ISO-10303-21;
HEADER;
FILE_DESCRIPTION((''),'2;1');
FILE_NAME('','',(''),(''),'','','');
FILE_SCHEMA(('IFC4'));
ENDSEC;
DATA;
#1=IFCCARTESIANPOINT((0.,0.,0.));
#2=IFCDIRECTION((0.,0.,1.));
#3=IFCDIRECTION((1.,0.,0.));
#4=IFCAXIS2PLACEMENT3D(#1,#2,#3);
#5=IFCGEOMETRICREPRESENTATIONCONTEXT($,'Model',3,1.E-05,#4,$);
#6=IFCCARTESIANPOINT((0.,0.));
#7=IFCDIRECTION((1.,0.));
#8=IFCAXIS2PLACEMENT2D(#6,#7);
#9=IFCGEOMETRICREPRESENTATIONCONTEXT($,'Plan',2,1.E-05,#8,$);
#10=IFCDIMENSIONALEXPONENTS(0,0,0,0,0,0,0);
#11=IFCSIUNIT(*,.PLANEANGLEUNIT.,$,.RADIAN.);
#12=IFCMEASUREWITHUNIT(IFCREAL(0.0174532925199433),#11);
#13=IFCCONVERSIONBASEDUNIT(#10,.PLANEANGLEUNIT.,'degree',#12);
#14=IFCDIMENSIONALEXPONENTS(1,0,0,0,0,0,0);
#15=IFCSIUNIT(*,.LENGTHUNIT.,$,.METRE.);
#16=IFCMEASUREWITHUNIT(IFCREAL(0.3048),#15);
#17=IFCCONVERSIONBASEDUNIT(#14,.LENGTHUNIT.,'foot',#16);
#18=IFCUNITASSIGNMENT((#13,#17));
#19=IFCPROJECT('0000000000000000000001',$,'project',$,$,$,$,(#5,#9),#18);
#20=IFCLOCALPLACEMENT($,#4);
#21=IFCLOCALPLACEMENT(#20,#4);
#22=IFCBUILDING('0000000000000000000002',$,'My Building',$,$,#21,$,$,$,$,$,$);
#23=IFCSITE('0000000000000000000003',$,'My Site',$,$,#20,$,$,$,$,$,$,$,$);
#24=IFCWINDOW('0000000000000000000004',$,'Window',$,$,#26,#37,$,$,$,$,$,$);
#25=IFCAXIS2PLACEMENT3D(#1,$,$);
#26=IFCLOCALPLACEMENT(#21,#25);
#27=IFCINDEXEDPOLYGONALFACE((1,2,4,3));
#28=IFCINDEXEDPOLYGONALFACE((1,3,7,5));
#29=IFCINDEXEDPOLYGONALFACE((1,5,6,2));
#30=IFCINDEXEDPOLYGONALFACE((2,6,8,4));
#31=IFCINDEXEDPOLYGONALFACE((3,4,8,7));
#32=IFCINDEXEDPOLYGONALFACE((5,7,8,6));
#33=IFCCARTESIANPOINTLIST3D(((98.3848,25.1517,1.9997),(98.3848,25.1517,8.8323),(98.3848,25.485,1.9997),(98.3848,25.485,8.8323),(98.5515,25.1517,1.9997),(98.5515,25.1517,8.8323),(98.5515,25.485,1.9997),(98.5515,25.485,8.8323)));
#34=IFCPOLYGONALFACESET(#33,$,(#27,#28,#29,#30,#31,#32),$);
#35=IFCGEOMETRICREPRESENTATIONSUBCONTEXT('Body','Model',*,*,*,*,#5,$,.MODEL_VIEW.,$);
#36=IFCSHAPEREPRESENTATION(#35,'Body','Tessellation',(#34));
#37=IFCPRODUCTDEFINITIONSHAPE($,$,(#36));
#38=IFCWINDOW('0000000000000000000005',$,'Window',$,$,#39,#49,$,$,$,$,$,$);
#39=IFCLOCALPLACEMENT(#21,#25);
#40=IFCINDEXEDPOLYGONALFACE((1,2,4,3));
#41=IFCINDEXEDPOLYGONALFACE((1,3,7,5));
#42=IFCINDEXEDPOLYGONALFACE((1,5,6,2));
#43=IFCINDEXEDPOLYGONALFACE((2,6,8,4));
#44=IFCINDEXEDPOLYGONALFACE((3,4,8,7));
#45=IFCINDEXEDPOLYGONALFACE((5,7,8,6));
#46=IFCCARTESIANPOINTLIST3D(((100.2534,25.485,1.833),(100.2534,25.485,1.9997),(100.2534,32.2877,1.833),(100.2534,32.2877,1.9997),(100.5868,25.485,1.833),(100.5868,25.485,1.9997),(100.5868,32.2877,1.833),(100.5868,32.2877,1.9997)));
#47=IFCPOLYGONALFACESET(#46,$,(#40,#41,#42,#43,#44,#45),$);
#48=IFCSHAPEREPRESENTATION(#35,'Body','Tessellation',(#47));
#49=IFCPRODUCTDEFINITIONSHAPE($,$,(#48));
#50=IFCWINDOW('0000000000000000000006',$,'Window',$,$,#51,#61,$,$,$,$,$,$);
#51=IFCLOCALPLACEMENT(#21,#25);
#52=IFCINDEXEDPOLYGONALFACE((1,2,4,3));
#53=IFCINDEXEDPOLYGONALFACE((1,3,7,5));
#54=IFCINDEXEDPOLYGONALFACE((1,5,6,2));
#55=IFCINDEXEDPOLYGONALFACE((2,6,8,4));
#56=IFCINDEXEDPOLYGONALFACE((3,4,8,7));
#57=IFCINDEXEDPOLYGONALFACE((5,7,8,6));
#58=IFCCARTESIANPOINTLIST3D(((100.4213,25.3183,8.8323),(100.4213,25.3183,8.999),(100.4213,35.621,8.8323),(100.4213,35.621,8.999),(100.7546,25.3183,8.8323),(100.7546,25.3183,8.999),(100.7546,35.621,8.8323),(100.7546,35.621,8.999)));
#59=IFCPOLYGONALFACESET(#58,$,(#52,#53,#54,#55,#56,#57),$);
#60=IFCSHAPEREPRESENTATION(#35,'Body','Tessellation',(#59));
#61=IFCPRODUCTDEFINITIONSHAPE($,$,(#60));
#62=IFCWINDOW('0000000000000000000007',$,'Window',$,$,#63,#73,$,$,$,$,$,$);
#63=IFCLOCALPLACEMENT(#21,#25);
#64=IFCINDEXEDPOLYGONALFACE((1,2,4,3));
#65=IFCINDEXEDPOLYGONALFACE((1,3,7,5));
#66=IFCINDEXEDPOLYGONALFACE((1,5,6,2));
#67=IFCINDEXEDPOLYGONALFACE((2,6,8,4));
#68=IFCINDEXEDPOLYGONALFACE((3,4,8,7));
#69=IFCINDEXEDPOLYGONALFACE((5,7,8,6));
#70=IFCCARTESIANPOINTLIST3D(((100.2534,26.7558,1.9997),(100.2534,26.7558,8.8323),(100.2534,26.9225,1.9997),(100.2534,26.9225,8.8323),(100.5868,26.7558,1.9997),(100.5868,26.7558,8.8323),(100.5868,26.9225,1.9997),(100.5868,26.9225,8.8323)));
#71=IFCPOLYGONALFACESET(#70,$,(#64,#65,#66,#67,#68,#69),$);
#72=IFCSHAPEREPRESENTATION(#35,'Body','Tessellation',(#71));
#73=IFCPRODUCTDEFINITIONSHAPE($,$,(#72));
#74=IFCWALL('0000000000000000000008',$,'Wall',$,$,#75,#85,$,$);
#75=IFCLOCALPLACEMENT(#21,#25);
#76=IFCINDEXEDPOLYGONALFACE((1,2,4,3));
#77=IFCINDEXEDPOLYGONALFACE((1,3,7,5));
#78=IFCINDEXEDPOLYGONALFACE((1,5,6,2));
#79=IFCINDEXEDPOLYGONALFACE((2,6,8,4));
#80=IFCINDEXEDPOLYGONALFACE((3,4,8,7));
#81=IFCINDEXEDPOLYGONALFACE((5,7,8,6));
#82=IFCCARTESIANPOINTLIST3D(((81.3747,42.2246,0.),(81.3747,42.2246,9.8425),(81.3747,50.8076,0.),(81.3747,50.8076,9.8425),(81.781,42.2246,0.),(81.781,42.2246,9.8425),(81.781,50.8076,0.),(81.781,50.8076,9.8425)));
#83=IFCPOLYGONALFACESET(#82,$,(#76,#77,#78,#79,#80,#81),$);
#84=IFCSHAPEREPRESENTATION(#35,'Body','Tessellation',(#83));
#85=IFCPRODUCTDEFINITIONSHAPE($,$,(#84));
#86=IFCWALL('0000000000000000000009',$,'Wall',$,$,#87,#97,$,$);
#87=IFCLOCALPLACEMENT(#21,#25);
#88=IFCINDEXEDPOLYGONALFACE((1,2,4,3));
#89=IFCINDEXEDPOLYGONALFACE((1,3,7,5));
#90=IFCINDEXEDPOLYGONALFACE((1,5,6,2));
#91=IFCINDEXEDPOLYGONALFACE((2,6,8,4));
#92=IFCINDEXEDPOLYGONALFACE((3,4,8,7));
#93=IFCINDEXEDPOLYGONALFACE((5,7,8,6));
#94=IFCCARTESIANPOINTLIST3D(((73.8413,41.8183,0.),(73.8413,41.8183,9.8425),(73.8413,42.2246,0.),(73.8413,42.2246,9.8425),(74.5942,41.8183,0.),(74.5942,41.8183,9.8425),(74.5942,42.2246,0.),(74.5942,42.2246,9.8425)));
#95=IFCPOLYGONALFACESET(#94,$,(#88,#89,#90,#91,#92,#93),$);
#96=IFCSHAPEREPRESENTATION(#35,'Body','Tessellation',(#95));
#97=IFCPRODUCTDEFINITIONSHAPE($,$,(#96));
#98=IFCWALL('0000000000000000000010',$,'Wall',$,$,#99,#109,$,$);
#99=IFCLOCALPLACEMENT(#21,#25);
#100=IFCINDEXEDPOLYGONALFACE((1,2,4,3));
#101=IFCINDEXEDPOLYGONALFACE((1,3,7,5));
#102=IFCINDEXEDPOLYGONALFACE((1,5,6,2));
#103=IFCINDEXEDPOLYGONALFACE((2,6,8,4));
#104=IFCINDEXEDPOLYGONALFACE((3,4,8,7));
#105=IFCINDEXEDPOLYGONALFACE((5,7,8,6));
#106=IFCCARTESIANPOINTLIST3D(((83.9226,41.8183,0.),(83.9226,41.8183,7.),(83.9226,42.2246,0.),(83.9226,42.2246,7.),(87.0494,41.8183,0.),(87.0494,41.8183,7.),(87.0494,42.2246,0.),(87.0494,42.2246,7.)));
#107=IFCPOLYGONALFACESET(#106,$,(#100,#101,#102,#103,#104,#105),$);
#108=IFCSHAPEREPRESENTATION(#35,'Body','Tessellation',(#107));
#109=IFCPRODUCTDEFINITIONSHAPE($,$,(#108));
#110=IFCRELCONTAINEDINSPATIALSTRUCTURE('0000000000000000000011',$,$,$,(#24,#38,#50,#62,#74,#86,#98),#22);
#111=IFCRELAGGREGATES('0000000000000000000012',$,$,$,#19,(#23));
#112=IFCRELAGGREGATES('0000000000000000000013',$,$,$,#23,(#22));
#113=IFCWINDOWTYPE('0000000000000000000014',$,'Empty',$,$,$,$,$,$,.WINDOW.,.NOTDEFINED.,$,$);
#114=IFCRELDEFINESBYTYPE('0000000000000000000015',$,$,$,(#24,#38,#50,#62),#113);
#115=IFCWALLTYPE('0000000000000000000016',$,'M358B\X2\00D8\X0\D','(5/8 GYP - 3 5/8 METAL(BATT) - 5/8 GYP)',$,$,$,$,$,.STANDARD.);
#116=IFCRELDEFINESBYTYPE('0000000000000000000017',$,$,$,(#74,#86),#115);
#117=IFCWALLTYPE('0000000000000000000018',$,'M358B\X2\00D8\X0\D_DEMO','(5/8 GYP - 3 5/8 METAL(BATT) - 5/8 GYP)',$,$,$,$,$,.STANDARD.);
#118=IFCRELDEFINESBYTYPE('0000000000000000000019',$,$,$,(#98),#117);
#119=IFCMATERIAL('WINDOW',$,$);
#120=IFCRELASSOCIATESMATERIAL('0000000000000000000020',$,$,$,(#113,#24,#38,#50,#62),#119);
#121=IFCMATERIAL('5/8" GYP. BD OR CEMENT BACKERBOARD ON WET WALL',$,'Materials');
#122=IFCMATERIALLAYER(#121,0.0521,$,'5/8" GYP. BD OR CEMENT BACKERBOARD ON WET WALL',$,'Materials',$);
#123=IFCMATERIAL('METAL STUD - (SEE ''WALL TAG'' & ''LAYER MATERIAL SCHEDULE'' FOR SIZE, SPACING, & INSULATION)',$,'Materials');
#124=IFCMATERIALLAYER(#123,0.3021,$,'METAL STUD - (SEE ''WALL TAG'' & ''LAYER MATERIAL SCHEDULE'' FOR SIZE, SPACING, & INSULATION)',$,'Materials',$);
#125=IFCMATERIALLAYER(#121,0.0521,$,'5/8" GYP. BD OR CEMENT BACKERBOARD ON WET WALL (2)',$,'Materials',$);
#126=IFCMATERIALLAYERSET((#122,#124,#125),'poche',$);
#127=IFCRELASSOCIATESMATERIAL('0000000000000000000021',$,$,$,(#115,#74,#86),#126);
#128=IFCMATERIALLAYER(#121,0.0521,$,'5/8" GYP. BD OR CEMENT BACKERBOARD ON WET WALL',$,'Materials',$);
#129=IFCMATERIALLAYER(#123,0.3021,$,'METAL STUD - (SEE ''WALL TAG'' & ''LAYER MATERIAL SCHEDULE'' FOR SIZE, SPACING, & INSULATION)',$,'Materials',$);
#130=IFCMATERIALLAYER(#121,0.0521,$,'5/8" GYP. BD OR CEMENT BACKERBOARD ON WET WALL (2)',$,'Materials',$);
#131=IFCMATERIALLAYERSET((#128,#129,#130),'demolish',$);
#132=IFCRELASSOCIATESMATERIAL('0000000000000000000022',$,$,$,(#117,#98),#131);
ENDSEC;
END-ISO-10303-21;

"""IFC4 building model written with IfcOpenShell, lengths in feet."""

from ifc_helpers import new_model, entity, si_unit, converted_unit, frame, origin_with_axes, origin_2d_with_axis, place, context, subcontext, project, spatial, indexed_curve, rectangle, outline, extrude, material, layer, layer_set, layer_usage, material_profile, profile_set, profile_usage, type_object, element, save


model = new_model("IFC4")

# Units and contexts
model_context = context("Model", 3, precision=1e-05, world=origin_with_axes())
plan_context = context("Plan", 2, precision=1e-05, world=origin_2d_with_axis())
body_context_1 = subcontext(model_context, "Body", "Model", "MODEL_VIEW")
ifc_project = project(units=[converted_unit("PLANEANGLEUNIT", "degree", entity("IfcReal", 0.0174532925199433), si_unit("PLANEANGLEUNIT", "RADIAN"), dimensions=[0, 0, 0, 0, 0, 0, 0]), converted_unit("LENGTHUNIT", "foot", entity("IfcReal", 0.3048), si_unit("LENGTHUNIT", "METRE"), dimensions=[1, 0, 0, 0, 0, 0, 0])], contexts=[model_context, plan_context])

# Site, building
site_placement = place(None, origin_with_axes())
site = spatial("IfcSite", under=ifc_project, at=site_placement, Name="My Site")
building_placement = place(site_placement, origin_with_axes())
building = spatial("IfcBuilding", under=site, at=building_placement, Name="My Building")

# Shared definitions
ifc_material_1 = material(Name="WINDOW")

# Shared definitions
ifc_material_2 = material(Name="5/8\" GYP. BD OR CEMENT BACKERBOARD ON WET WALL", Category="Materials")
ifc_material_3 = material(Name="METAL STUD - (SEE 'WALL TAG' & 'LAYER MATERIAL SCHEDULE' FOR SIZE, SPACING, & INSULATION)", Category="Materials")

# Windows
ifc_material_profile = material_profile(ifc_material_1, rectangle(XDim=0.3333, YDim=0.1667, at=origin_2d_with_axis()))
ifc_profile_set = profile_set([ifc_material_profile], Name="existing")
window_type = type_object("IfcWindowType", Name="Empty", PartitioningType="NOTDEFINED", PredefinedType="WINDOW", material=ifc_profile_set)
ifc_profile_usage_1 = profile_usage(ifc_profile_set, cardinal=5)
window_1_placement = place(building_placement, frame((98.4681, 25.3183, 1.9997), z_axis=(0.000001, 0.0, 1.0), x_axis=(0.0, 1.0, 0.0)))
element("IfcWindow", 1, at=window_1_placement, inside=building, type_object=window_type, material=ifc_profile_usage_1, Name="Window", context=body_context_1, shape_type="SweptSolid", body=[
    extrude(rectangle(XDim=0.3333, YDim=0.1667, at=origin_2d_with_axis()), origin_with_axes(), (0.0, 0.0, 1.0), 6.8327),
])
ifc_profile_usage_2 = profile_usage(ifc_profile_set, cardinal=5)
window_2_placement = place(building_placement, frame((100.4201, 32.2877, 1.9163), z_axis=(0.0, -1.0, 0.0), x_axis=(1.0, 0.0, 0.0)))
element("IfcWindow", 2, at=window_2_placement, inside=building, type_object=window_type, material=ifc_profile_usage_2, Name="Window", context=body_context_1, shape_type="SweptSolid", body=[
    extrude(rectangle(XDim=0.3333, YDim=0.1667, at=origin_2d_with_axis()), origin_with_axes(), (0.0, 0.0, 1.0), 6.8027),
])
ifc_profile_usage_3 = profile_usage(ifc_profile_set, cardinal=5)
window_3_placement = place(building_placement, frame((100.5879, 35.621, 8.9157), z_axis=(0.0, -1.0, 0.0), x_axis=(1.0, 0.0, 0.0)))
element("IfcWindow", 3, at=window_3_placement, inside=building, type_object=window_type, material=ifc_profile_usage_3, Name="Window", context=body_context_1, shape_type="SweptSolid", body=[
    extrude(rectangle(XDim=0.3333, YDim=0.1667, at=origin_2d_with_axis()), origin_with_axes(), (0.0, 0.0, 1.0), 10.3026),
])
ifc_profile_usage_4 = profile_usage(ifc_profile_set, cardinal=5)
window_4_placement = place(building_placement, frame((100.4201, 26.8391, 1.9997), z_axis=(0.0, -0.000001, 1.0), x_axis=(1.0, 0.0, 0.0)))
element("IfcWindow", 4, at=window_4_placement, inside=building, type_object=window_type, material=ifc_profile_usage_4, Name="Window", context=body_context_1, shape_type="SweptSolid", body=[
    extrude(rectangle(XDim=0.3333, YDim=0.1667, at=origin_2d_with_axis()), origin_with_axes(), (0.0, 0.0, 1.0), 6.8327),
])

# Walls
ifc_layer_1 = layer(ifc_material_2, 0.0521, Name="5/8\" GYP. BD OR CEMENT BACKERBOARD ON WET WALL", Category="Materials")
ifc_layer_2 = layer(ifc_material_3, 0.3021, Name="METAL STUD - (SEE 'WALL TAG' & 'LAYER MATERIAL SCHEDULE' FOR SIZE, SPACING, & INSULATION)", Category="Materials")
ifc_layer_3 = layer(ifc_material_2, 0.0521, Name="5/8\" GYP. BD OR CEMENT BACKERBOARD ON WET WALL (2)", Category="Materials")
ifc_layer_set_1 = layer_set([ifc_layer_1, ifc_layer_2, ifc_layer_3], Name="poche")
ifc_layer_usage_1 = layer_usage(ifc_layer_set_1, "AXIS2", "POSITIVE", 0.0)
wall_type_1 = type_object("IfcWallType", Name="M358BØD", Description="(5/8 GYP - 3 5/8 METAL(BATT) - 5/8 GYP)", PredefinedType="STANDARD", material=ifc_layer_set_1)
wall_1_placement = place(building_placement, frame((81.3747, 50.8076, 0.0), z_axis=(0.0, 0.0, 1.0), x_axis=(0.0, -1.0, 0.0)))
element("IfcWall", 5, at=wall_1_placement, inside=building, type_object=wall_type_1, material=ifc_layer_usage_1, Name="Wall", context=body_context_1, shape_type="SweptSolid", body=[
    extrude(outline(indexed_curve([(0.0, 0.0), (0.0, 0.4062), (8.583, 0.4062), (8.583, 0.0), (0.0, 0.0)], self_intersect=False)), origin_with_axes(), (0.0, 0.0, 1.0), 9.8425),
])
ifc_layer_usage_2 = layer_usage(ifc_layer_set_1, "AXIS2", "POSITIVE", 0.0)
wall_2_placement = place(building_placement, frame((74.5942, 42.2246, 0.0), z_axis=(0.0, 0.0, 1.0), x_axis=(-1.0, 0.0, 0.0)))
element("IfcWall", 6, at=wall_2_placement, inside=building, type_object=wall_type_1, material=ifc_layer_usage_2, Name="Wall", context=body_context_1, shape_type="SweptSolid", body=[
    extrude(outline(indexed_curve([(0.0, 0.0), (0.0, 0.4062), (0.7528, 0.4062), (0.7528, 0.0), (0.0, 0.0)], self_intersect=False)), origin_with_axes(), (0.0, 0.0, 1.0), 9.8425),
])
ifc_layer_4 = layer(ifc_material_2, 0.0521, Name="5/8\" GYP. BD OR CEMENT BACKERBOARD ON WET WALL", Category="Materials")
ifc_layer_5 = layer(ifc_material_3, 0.3021, Name="METAL STUD - (SEE 'WALL TAG' & 'LAYER MATERIAL SCHEDULE' FOR SIZE, SPACING, & INSULATION)", Category="Materials")
ifc_layer_6 = layer(ifc_material_2, 0.0521, Name="5/8\" GYP. BD OR CEMENT BACKERBOARD ON WET WALL (2)", Category="Materials")
ifc_layer_set_2 = layer_set([ifc_layer_4, ifc_layer_5, ifc_layer_6], Name="demolish")
wall_type_2 = type_object("IfcWallType", Name="M358BØD_DEMO", Description="(5/8 GYP - 3 5/8 METAL(BATT) - 5/8 GYP)", PredefinedType="STANDARD", material=ifc_layer_set_2)

# Wall
ifc_layer_usage_3 = layer_usage(ifc_layer_set_2, "AXIS2", "POSITIVE", 0.0)
wall_3_placement = place(building_placement, frame((87.0494, 42.2246, 0.0), z_axis=(0.0, 0.0, 1.0), x_axis=(-1.0, 0.0, 0.0)))
element("IfcWall", 7, at=wall_3_placement, inside=building, type_object=wall_type_2, material=ifc_layer_usage_3, Name="Wall", context=body_context_1, shape_type="SweptSolid", body=[
    extrude(outline(indexed_curve([(0.0, 0.0), (0.0, 0.4062), (3.1267, 0.4062), (3.1267, 0.0), (0.0, 0.0)], self_intersect=False)), origin_with_axes(), (0.0, 0.0, 1.0), 7.0),
])

save(model, "model.ifc")
